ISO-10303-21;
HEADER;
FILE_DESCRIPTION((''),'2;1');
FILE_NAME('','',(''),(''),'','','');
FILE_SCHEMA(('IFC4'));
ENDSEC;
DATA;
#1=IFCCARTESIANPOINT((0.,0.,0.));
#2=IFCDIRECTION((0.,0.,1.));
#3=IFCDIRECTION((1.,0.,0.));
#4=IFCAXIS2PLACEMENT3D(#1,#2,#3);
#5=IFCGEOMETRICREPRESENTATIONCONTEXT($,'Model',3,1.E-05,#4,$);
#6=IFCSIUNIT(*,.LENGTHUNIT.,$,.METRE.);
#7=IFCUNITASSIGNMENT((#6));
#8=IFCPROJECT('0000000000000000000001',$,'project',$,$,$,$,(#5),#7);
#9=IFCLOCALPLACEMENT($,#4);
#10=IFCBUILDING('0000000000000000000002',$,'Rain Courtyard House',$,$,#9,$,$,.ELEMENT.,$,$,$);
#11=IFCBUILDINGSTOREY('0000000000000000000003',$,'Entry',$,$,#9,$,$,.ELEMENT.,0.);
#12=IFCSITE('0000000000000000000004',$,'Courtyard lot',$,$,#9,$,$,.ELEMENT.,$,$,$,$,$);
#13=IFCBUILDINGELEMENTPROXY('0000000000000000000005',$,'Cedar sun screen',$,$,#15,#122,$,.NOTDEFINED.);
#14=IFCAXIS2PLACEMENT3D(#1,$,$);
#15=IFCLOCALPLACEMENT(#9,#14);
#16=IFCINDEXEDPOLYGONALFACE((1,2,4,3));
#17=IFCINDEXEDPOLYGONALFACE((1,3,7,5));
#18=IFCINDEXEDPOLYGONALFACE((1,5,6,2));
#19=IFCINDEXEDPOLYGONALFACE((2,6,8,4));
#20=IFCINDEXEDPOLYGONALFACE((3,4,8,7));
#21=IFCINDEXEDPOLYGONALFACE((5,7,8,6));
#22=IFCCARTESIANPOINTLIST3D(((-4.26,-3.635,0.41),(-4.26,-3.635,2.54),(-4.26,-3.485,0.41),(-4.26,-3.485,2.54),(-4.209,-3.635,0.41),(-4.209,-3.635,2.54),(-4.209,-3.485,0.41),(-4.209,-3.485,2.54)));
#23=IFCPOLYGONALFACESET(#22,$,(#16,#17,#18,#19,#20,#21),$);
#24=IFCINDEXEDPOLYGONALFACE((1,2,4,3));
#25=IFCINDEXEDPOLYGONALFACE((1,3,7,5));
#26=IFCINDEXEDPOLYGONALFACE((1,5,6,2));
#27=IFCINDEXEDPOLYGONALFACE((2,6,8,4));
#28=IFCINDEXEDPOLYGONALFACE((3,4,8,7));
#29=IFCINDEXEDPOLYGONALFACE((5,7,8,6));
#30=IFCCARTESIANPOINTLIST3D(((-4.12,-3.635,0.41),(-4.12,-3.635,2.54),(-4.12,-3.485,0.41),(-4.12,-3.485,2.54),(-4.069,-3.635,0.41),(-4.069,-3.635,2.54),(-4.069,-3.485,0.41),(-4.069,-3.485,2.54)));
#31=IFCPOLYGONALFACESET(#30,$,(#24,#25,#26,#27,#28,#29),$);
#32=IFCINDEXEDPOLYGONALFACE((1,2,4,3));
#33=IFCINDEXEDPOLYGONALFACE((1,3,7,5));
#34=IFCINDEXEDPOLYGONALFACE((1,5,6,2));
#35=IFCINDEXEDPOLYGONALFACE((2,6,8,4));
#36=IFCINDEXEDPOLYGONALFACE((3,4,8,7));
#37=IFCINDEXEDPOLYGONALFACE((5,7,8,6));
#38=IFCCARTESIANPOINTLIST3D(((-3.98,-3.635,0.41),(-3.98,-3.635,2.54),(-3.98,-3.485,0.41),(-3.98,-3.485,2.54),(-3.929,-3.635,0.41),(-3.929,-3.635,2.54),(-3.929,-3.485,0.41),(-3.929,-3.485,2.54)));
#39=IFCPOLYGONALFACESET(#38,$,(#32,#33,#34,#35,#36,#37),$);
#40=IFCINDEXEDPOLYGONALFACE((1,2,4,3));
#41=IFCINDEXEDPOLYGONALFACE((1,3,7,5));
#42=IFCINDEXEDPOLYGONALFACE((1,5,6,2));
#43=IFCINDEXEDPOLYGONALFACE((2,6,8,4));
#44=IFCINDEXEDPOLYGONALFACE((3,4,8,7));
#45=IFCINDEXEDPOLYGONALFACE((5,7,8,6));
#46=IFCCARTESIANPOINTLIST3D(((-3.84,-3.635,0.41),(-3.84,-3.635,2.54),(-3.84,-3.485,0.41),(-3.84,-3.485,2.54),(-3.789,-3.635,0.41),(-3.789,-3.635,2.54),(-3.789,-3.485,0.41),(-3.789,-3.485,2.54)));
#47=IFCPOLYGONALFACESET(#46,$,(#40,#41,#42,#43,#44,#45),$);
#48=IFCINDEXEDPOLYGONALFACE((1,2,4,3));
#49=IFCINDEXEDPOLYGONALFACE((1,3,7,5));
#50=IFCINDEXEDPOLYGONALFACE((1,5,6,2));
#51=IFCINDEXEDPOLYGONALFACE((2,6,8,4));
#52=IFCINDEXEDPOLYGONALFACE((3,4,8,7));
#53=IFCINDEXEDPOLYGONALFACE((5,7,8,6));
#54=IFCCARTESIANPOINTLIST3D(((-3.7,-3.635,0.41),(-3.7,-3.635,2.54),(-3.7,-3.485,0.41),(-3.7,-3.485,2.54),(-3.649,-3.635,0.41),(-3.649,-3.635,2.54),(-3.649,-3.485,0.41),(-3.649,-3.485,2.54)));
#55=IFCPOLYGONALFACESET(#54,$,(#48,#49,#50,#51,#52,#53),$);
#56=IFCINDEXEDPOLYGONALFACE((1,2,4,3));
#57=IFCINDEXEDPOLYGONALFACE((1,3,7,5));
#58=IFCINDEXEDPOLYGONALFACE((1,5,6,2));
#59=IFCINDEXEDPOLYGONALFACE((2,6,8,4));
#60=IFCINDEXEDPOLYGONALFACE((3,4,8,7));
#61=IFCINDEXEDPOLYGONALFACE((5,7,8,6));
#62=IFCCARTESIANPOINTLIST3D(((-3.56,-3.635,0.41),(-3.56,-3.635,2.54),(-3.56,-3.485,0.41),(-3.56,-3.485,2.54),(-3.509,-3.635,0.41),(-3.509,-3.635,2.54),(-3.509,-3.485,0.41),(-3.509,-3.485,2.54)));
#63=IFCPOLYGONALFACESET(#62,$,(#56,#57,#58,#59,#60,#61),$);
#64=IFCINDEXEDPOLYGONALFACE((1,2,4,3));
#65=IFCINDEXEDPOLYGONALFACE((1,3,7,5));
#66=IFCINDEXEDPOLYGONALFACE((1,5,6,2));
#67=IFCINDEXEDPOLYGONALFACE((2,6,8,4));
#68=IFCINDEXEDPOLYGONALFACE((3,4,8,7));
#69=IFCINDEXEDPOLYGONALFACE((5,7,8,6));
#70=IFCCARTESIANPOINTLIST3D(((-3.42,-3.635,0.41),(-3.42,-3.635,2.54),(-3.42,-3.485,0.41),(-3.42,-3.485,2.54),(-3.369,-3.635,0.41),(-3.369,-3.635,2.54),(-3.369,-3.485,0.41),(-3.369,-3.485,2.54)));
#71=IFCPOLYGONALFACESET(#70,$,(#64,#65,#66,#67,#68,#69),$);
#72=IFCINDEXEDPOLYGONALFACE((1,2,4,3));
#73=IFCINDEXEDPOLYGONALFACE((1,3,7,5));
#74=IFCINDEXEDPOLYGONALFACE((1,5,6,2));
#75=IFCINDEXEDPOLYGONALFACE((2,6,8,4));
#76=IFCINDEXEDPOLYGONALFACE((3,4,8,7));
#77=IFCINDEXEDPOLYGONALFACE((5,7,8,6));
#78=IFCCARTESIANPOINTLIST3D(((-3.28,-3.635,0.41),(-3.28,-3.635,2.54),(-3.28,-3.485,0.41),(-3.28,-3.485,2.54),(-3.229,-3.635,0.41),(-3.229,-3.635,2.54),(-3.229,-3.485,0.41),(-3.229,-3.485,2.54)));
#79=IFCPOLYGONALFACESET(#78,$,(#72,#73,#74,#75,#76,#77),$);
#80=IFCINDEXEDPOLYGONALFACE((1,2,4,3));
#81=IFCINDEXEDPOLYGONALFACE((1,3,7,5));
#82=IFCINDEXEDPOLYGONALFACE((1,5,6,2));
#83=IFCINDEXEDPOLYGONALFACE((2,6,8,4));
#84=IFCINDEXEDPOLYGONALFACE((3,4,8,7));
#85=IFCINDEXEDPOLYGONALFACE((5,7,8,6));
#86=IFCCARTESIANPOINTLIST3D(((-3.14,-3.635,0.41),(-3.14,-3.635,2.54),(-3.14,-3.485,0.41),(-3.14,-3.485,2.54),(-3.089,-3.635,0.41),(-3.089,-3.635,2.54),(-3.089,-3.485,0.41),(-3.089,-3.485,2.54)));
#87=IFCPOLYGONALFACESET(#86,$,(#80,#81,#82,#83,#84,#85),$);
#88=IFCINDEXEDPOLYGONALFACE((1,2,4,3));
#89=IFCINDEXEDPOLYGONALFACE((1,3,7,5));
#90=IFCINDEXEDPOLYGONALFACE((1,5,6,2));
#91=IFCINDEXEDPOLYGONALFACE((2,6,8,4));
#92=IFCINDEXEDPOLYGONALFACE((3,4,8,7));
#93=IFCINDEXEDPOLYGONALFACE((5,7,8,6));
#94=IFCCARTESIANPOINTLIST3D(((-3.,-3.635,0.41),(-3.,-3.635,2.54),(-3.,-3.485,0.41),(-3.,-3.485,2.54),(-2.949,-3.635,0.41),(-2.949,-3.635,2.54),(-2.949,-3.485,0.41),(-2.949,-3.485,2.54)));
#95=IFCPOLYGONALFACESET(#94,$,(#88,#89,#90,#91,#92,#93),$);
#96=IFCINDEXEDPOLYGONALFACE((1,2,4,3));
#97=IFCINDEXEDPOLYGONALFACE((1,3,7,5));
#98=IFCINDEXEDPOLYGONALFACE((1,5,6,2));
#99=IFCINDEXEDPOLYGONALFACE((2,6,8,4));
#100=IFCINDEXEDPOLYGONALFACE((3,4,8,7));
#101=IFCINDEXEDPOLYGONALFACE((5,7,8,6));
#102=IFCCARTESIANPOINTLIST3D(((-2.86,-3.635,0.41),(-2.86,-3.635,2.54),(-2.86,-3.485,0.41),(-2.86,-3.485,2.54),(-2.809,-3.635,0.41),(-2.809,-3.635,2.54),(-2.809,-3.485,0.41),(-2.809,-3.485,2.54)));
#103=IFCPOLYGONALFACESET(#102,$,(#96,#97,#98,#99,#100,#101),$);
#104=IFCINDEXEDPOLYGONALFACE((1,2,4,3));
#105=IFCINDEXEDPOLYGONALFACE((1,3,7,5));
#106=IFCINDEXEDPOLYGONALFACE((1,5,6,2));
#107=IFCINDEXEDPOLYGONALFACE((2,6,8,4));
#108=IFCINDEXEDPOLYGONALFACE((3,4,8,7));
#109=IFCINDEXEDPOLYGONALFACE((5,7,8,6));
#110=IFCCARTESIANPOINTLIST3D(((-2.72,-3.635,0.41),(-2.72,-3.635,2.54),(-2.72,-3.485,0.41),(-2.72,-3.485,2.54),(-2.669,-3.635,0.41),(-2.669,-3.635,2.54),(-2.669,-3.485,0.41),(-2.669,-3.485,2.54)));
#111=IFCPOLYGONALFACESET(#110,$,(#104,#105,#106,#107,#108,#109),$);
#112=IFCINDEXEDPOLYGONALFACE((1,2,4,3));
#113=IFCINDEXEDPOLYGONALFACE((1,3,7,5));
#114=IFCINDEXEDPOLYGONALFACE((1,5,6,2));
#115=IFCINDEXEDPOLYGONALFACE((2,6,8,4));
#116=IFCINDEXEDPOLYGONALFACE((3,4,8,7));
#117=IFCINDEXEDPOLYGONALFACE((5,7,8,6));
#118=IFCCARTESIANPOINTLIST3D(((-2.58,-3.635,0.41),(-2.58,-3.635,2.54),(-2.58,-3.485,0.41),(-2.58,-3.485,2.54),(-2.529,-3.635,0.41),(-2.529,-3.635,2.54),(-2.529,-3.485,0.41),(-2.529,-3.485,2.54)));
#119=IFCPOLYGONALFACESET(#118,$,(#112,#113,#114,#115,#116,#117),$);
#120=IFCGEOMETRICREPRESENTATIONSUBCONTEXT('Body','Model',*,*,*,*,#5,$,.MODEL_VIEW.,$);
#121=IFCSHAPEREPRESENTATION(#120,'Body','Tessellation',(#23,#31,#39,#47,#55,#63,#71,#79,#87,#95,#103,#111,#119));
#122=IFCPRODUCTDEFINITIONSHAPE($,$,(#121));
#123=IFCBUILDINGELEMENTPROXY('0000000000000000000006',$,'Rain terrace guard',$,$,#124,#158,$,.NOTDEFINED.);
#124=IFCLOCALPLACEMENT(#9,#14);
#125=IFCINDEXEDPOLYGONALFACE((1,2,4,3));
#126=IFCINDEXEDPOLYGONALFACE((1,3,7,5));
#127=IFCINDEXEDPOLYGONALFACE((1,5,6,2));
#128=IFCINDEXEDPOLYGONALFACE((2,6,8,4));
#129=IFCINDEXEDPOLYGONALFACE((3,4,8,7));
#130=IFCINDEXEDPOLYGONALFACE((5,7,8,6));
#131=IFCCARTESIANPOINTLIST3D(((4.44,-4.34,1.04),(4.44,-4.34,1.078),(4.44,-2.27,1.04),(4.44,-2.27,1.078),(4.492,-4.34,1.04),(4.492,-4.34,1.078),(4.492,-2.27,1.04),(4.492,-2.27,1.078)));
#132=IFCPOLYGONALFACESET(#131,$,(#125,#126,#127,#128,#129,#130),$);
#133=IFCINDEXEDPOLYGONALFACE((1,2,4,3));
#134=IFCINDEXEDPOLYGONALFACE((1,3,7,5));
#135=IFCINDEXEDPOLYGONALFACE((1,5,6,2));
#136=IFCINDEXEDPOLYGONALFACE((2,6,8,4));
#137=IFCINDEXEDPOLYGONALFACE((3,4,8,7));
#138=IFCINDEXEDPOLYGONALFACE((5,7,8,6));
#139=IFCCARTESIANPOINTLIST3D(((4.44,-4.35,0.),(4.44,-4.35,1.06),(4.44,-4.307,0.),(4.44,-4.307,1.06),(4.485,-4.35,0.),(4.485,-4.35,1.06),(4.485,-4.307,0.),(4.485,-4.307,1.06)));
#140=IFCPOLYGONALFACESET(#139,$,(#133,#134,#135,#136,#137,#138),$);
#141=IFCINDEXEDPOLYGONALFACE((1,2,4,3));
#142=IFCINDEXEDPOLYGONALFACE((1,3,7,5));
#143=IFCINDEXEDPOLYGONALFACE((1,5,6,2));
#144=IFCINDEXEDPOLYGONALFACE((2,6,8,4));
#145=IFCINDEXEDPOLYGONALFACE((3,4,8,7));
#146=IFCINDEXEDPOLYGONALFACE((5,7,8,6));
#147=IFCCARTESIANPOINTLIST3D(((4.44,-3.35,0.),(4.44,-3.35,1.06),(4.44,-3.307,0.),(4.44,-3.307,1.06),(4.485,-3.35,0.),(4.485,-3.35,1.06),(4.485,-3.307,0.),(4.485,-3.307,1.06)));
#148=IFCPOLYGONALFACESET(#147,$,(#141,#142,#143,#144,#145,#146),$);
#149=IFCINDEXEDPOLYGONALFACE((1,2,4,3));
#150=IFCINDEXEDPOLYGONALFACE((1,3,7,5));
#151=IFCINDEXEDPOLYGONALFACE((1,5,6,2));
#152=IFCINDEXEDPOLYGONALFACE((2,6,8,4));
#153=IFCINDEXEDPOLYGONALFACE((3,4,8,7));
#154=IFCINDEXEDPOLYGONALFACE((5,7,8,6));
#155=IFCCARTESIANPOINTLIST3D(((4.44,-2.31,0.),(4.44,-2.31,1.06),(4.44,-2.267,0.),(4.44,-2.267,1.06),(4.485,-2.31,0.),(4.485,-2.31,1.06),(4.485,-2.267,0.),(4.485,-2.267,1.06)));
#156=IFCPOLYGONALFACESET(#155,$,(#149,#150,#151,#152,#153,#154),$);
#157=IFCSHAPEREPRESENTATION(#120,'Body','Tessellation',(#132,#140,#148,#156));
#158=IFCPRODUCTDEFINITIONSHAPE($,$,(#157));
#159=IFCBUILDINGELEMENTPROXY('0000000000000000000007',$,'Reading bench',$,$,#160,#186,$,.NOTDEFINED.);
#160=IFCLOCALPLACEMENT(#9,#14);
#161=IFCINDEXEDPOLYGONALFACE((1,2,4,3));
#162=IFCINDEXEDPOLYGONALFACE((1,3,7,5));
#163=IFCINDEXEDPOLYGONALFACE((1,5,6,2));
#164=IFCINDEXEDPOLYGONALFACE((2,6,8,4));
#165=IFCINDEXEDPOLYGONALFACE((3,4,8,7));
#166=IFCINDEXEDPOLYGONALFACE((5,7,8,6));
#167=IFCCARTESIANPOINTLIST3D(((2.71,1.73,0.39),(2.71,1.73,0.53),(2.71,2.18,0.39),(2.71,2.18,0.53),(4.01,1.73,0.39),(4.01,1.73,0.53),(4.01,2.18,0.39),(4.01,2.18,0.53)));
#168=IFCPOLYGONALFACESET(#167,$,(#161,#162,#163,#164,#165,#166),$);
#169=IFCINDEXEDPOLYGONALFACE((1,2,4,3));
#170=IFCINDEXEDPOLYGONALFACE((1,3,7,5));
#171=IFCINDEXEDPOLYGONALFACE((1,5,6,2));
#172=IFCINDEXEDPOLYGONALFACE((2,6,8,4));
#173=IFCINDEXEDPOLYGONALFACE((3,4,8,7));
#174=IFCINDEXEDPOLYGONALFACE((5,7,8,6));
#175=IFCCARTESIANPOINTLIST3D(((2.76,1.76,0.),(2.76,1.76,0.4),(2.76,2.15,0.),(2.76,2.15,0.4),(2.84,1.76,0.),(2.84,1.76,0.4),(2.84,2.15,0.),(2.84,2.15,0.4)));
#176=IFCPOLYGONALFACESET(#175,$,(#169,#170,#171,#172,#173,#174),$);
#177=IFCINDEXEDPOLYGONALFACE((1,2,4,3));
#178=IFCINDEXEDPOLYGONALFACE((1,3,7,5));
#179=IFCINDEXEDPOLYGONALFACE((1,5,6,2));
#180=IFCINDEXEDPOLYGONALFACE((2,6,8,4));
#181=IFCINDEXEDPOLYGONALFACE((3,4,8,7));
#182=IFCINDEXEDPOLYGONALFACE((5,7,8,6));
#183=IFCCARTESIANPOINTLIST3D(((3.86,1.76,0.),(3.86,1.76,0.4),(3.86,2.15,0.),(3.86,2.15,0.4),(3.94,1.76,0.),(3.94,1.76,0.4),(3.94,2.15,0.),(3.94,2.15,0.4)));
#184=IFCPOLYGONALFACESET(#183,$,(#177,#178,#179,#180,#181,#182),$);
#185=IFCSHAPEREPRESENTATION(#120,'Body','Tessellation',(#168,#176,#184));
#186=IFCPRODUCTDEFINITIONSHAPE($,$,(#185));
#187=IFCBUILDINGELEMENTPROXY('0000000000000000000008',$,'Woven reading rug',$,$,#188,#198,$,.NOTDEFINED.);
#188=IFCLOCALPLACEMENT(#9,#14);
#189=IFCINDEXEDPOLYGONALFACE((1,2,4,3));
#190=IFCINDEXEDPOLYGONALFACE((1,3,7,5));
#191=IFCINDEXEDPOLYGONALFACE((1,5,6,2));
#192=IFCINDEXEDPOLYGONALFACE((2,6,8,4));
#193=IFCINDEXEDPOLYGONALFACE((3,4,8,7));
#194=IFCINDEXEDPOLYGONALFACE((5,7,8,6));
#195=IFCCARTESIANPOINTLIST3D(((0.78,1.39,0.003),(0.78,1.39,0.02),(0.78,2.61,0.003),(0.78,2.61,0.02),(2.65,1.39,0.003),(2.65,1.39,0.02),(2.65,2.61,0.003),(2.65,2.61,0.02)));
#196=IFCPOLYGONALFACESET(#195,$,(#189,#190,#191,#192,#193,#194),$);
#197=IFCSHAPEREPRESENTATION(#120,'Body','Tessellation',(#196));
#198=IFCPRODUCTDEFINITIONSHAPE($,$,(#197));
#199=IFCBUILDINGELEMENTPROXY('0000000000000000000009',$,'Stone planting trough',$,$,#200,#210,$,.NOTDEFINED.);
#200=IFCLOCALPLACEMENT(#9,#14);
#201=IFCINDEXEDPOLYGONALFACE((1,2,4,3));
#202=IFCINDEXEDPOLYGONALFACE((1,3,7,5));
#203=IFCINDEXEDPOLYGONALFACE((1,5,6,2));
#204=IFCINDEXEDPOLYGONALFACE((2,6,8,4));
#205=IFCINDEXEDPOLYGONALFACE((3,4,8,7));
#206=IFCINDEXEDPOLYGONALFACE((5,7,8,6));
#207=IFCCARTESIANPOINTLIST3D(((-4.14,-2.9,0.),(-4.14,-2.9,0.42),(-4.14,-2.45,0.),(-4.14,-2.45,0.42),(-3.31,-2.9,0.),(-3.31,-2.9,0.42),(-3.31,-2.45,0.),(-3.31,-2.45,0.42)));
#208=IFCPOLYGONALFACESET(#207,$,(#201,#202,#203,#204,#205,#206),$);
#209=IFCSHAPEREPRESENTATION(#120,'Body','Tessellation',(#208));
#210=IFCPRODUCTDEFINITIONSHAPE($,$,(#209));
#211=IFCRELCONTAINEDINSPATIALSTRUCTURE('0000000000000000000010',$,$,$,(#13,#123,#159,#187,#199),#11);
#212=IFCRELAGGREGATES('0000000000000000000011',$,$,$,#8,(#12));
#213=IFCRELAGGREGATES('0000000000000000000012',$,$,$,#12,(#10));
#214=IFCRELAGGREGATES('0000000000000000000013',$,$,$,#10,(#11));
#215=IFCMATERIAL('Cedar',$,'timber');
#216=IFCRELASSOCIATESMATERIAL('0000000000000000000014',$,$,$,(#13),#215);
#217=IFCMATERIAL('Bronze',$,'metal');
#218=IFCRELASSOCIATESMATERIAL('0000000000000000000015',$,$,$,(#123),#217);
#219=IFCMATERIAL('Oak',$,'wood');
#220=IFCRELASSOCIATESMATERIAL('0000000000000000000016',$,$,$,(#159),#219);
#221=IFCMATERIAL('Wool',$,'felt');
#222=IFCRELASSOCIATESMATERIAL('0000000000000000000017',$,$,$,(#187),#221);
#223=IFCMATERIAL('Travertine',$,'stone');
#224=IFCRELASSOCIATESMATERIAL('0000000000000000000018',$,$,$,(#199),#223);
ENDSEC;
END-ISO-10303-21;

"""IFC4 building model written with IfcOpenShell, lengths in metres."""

from ifc_helpers import new_model, si_unit, frame, origin_with_axes, origin_2d, place, context, subcontext, project, spatial, rectangle, extrude, material, element, save


model = new_model("IFC4")

# Units and contexts
model_context = context("Model", 3, precision=1e-05, world=origin_with_axes())
body_context = subcontext(model_context, "Body", "Model", "MODEL_VIEW")
ifc_project = project(units=[si_unit("LENGTHUNIT", "METRE")], contexts=[model_context])

# Site, building, storey
placement = place(None, origin_with_axes())
site = spatial("IfcSite", under=ifc_project, at=placement, Name="Courtyard lot", CompositionType="ELEMENT")
building = spatial("IfcBuilding", under=site, at=placement, Name="Rain Courtyard House", CompositionType="ELEMENT")
storey = spatial("IfcBuildingStorey", under=building, at=placement, Name="Entry", CompositionType="ELEMENT", Elevation=0.0)

# Building element proxies
ifc_material_1 = material(Name="Bronze", Category="metal")
ifc_material_2 = material(Name="Cedar", Category="timber")
element("IfcBuildingElementProxy", 1, at=placement, inside=storey, material=ifc_material_2, Name="Cedar sun screen", PredefinedType="NOTDEFINED", context=body_context, shape_type="SweptSolid", body=[
    extrude(rectangle(XDim=0.051, YDim=0.15, at=origin_2d()), frame((-4.2345, -3.56, 0.41), z_axis=(0.0, 0.0, 1.0), x_axis=(1.0, 0.0, 0.0)), (0.0, 0.0, 1.0), 2.13),
    extrude(rectangle(XDim=0.051, YDim=0.15, at=origin_2d()), frame((-4.0945, -3.56, 0.41), z_axis=(0.0, 0.0, 1.0), x_axis=(1.0, 0.0, 0.0)), (0.0, 0.0, 1.0), 2.13),
    extrude(rectangle(XDim=0.051, YDim=0.15, at=origin_2d()), frame((-3.9545, -3.56, 0.41), z_axis=(0.0, 0.0, 1.0), x_axis=(1.0, 0.0, 0.0)), (0.0, 0.0, 1.0), 2.13),
    extrude(rectangle(XDim=0.051, YDim=0.15, at=origin_2d()), frame((-3.8145, -3.56, 0.41), z_axis=(0.0, 0.0, 1.0), x_axis=(1.0, 0.0, 0.0)), (0.0, 0.0, 1.0), 2.13),
    extrude(rectangle(XDim=0.051, YDim=0.15, at=origin_2d()), frame((-3.6745, -3.56, 0.41), z_axis=(0.0, 0.0, 1.0), x_axis=(1.0, 0.0, 0.0)), (0.0, 0.0, 1.0), 2.13),
    extrude(rectangle(XDim=0.051, YDim=0.15, at=origin_2d()), frame((-3.5345, -3.56, 0.41), z_axis=(0.0, 0.0, 1.0), x_axis=(1.0, 0.0, 0.0)), (0.0, 0.0, 1.0), 2.13),
    extrude(rectangle(XDim=0.051, YDim=0.15, at=origin_2d()), frame((-3.3945, -3.56, 0.41), z_axis=(0.0, 0.0, 1.0), x_axis=(1.0, 0.0, 0.0)), (0.0, 0.0, 1.0), 2.13),
    extrude(rectangle(XDim=0.051, YDim=0.15, at=origin_2d()), frame((-3.2545, -3.56, 0.41), z_axis=(0.0, 0.0, 1.0), x_axis=(1.0, 0.0, 0.0)), (0.0, 0.0, 1.0), 2.13),
    extrude(rectangle(XDim=0.051, YDim=0.15, at=origin_2d()), frame((-3.1145, -3.56, 0.41), z_axis=(0.0, 0.0, 1.0), x_axis=(1.0, 0.0, 0.0)), (0.0, 0.0, 1.0), 2.13),
    extrude(rectangle(XDim=0.051, YDim=0.15, at=origin_2d()), frame((-2.9745, -3.56, 0.41), z_axis=(0.0, 0.0, 1.0), x_axis=(1.0, 0.0, 0.0)), (0.0, 0.0, 1.0), 2.13),
    extrude(rectangle(XDim=0.051, YDim=0.15, at=origin_2d()), frame((-2.8345, -3.56, 0.41), z_axis=(0.0, 0.0, 1.0), x_axis=(1.0, 0.0, 0.0)), (0.0, 0.0, 1.0), 2.13),
    extrude(rectangle(XDim=0.051, YDim=0.15, at=origin_2d()), frame((-2.6945, -3.56, 0.41), z_axis=(0.0, 0.0, 1.0), x_axis=(1.0, 0.0, 0.0)), (0.0, 0.0, 1.0), 2.13),
    extrude(rectangle(XDim=0.051, YDim=0.15, at=origin_2d()), frame((-2.5545, -3.56, 0.41), z_axis=(0.0, 0.0, 1.0), x_axis=(1.0, 0.0, 0.0)), (0.0, 0.0, 1.0), 2.13),
])
element("IfcBuildingElementProxy", 2, at=placement, inside=storey, material=ifc_material_1, Name="Rain terrace guard", PredefinedType="NOTDEFINED", context=body_context, shape_type="SweptSolid", body=[
    extrude(rectangle(XDim=0.052, YDim=2.07, at=origin_2d()), frame((4.466, -3.305, 1.04), z_axis=(0.0, 0.0, 1.0), x_axis=(1.0, 0.0, 0.0)), (0.0, 0.0, 1.0), 0.038),
    extrude(rectangle(XDim=0.045, YDim=0.043, at=origin_2d()), frame((4.4625, -4.3285, 0.0), z_axis=(0.0, 0.0, 1.0), x_axis=(1.0, 0.0, 0.0)), (0.0, 0.0, 1.0), 1.06),
    extrude(rectangle(XDim=0.045, YDim=0.043, at=origin_2d()), frame((4.4625, -3.3285, 0.0), z_axis=(0.0, 0.0, 1.0), x_axis=(1.0, 0.0, 0.0)), (0.0, 0.0, 1.0), 1.06),
    extrude(rectangle(XDim=0.045, YDim=0.043, at=origin_2d()), frame((4.4625, -2.2885, 0.0), z_axis=(0.0, 0.0, 1.0), x_axis=(1.0, 0.0, 0.0)), (0.0, 0.0, 1.0), 1.06),
])
ifc_material_3 = material(Name="Oak", Category="wood")
element("IfcBuildingElementProxy", 3, at=placement, inside=storey, material=ifc_material_3, Name="Reading bench", PredefinedType="NOTDEFINED", context=body_context, shape_type="SweptSolid", body=[
    extrude(rectangle(XDim=1.3, YDim=0.45, at=origin_2d()), frame((3.36, 1.955, 0.39), z_axis=(0.0, 0.0, 1.0), x_axis=(1.0, 0.0, 0.0)), (0.0, 0.0, 1.0), 0.14),
    extrude(rectangle(XDim=0.08, YDim=0.39, at=origin_2d()), frame((2.8, 1.955, 0.0), z_axis=(0.0, 0.0, 1.0), x_axis=(1.0, 0.0, 0.0)), (0.0, 0.0, 1.0), 0.4),
    extrude(rectangle(XDim=0.08, YDim=0.39, at=origin_2d()), frame((3.9, 1.955, 0.0), z_axis=(0.0, 0.0, 1.0), x_axis=(1.0, 0.0, 0.0)), (0.0, 0.0, 1.0), 0.4),
])
ifc_material_4 = material(Name="Wool", Category="felt")
element("IfcBuildingElementProxy", 4, at=placement, inside=storey, material=ifc_material_4, Name="Woven reading rug", PredefinedType="NOTDEFINED", context=body_context, shape_type="SweptSolid", body=[
    extrude(rectangle(XDim=1.87, YDim=1.22, at=origin_2d()), frame((1.715, 2.0, 0.003), z_axis=(0.0, 0.0, 1.0), x_axis=(1.0, 0.0, 0.0)), (0.0, 0.0, 1.0), 0.017),
])
ifc_material_5 = material(Name="Travertine", Category="stone")
element("IfcBuildingElementProxy", 5, at=placement, inside=storey, material=ifc_material_5, Name="Stone planting trough", PredefinedType="NOTDEFINED", context=body_context, shape_type="SweptSolid", body=[
    extrude(rectangle(XDim=0.83, YDim=0.45, at=origin_2d()), frame((-3.725, -2.675, 0.0), z_axis=(0.0, 0.0, 1.0), x_axis=(1.0, 0.0, 0.0)), (0.0, 0.0, 1.0), 0.42),
])

save(model, "model.ifc")
